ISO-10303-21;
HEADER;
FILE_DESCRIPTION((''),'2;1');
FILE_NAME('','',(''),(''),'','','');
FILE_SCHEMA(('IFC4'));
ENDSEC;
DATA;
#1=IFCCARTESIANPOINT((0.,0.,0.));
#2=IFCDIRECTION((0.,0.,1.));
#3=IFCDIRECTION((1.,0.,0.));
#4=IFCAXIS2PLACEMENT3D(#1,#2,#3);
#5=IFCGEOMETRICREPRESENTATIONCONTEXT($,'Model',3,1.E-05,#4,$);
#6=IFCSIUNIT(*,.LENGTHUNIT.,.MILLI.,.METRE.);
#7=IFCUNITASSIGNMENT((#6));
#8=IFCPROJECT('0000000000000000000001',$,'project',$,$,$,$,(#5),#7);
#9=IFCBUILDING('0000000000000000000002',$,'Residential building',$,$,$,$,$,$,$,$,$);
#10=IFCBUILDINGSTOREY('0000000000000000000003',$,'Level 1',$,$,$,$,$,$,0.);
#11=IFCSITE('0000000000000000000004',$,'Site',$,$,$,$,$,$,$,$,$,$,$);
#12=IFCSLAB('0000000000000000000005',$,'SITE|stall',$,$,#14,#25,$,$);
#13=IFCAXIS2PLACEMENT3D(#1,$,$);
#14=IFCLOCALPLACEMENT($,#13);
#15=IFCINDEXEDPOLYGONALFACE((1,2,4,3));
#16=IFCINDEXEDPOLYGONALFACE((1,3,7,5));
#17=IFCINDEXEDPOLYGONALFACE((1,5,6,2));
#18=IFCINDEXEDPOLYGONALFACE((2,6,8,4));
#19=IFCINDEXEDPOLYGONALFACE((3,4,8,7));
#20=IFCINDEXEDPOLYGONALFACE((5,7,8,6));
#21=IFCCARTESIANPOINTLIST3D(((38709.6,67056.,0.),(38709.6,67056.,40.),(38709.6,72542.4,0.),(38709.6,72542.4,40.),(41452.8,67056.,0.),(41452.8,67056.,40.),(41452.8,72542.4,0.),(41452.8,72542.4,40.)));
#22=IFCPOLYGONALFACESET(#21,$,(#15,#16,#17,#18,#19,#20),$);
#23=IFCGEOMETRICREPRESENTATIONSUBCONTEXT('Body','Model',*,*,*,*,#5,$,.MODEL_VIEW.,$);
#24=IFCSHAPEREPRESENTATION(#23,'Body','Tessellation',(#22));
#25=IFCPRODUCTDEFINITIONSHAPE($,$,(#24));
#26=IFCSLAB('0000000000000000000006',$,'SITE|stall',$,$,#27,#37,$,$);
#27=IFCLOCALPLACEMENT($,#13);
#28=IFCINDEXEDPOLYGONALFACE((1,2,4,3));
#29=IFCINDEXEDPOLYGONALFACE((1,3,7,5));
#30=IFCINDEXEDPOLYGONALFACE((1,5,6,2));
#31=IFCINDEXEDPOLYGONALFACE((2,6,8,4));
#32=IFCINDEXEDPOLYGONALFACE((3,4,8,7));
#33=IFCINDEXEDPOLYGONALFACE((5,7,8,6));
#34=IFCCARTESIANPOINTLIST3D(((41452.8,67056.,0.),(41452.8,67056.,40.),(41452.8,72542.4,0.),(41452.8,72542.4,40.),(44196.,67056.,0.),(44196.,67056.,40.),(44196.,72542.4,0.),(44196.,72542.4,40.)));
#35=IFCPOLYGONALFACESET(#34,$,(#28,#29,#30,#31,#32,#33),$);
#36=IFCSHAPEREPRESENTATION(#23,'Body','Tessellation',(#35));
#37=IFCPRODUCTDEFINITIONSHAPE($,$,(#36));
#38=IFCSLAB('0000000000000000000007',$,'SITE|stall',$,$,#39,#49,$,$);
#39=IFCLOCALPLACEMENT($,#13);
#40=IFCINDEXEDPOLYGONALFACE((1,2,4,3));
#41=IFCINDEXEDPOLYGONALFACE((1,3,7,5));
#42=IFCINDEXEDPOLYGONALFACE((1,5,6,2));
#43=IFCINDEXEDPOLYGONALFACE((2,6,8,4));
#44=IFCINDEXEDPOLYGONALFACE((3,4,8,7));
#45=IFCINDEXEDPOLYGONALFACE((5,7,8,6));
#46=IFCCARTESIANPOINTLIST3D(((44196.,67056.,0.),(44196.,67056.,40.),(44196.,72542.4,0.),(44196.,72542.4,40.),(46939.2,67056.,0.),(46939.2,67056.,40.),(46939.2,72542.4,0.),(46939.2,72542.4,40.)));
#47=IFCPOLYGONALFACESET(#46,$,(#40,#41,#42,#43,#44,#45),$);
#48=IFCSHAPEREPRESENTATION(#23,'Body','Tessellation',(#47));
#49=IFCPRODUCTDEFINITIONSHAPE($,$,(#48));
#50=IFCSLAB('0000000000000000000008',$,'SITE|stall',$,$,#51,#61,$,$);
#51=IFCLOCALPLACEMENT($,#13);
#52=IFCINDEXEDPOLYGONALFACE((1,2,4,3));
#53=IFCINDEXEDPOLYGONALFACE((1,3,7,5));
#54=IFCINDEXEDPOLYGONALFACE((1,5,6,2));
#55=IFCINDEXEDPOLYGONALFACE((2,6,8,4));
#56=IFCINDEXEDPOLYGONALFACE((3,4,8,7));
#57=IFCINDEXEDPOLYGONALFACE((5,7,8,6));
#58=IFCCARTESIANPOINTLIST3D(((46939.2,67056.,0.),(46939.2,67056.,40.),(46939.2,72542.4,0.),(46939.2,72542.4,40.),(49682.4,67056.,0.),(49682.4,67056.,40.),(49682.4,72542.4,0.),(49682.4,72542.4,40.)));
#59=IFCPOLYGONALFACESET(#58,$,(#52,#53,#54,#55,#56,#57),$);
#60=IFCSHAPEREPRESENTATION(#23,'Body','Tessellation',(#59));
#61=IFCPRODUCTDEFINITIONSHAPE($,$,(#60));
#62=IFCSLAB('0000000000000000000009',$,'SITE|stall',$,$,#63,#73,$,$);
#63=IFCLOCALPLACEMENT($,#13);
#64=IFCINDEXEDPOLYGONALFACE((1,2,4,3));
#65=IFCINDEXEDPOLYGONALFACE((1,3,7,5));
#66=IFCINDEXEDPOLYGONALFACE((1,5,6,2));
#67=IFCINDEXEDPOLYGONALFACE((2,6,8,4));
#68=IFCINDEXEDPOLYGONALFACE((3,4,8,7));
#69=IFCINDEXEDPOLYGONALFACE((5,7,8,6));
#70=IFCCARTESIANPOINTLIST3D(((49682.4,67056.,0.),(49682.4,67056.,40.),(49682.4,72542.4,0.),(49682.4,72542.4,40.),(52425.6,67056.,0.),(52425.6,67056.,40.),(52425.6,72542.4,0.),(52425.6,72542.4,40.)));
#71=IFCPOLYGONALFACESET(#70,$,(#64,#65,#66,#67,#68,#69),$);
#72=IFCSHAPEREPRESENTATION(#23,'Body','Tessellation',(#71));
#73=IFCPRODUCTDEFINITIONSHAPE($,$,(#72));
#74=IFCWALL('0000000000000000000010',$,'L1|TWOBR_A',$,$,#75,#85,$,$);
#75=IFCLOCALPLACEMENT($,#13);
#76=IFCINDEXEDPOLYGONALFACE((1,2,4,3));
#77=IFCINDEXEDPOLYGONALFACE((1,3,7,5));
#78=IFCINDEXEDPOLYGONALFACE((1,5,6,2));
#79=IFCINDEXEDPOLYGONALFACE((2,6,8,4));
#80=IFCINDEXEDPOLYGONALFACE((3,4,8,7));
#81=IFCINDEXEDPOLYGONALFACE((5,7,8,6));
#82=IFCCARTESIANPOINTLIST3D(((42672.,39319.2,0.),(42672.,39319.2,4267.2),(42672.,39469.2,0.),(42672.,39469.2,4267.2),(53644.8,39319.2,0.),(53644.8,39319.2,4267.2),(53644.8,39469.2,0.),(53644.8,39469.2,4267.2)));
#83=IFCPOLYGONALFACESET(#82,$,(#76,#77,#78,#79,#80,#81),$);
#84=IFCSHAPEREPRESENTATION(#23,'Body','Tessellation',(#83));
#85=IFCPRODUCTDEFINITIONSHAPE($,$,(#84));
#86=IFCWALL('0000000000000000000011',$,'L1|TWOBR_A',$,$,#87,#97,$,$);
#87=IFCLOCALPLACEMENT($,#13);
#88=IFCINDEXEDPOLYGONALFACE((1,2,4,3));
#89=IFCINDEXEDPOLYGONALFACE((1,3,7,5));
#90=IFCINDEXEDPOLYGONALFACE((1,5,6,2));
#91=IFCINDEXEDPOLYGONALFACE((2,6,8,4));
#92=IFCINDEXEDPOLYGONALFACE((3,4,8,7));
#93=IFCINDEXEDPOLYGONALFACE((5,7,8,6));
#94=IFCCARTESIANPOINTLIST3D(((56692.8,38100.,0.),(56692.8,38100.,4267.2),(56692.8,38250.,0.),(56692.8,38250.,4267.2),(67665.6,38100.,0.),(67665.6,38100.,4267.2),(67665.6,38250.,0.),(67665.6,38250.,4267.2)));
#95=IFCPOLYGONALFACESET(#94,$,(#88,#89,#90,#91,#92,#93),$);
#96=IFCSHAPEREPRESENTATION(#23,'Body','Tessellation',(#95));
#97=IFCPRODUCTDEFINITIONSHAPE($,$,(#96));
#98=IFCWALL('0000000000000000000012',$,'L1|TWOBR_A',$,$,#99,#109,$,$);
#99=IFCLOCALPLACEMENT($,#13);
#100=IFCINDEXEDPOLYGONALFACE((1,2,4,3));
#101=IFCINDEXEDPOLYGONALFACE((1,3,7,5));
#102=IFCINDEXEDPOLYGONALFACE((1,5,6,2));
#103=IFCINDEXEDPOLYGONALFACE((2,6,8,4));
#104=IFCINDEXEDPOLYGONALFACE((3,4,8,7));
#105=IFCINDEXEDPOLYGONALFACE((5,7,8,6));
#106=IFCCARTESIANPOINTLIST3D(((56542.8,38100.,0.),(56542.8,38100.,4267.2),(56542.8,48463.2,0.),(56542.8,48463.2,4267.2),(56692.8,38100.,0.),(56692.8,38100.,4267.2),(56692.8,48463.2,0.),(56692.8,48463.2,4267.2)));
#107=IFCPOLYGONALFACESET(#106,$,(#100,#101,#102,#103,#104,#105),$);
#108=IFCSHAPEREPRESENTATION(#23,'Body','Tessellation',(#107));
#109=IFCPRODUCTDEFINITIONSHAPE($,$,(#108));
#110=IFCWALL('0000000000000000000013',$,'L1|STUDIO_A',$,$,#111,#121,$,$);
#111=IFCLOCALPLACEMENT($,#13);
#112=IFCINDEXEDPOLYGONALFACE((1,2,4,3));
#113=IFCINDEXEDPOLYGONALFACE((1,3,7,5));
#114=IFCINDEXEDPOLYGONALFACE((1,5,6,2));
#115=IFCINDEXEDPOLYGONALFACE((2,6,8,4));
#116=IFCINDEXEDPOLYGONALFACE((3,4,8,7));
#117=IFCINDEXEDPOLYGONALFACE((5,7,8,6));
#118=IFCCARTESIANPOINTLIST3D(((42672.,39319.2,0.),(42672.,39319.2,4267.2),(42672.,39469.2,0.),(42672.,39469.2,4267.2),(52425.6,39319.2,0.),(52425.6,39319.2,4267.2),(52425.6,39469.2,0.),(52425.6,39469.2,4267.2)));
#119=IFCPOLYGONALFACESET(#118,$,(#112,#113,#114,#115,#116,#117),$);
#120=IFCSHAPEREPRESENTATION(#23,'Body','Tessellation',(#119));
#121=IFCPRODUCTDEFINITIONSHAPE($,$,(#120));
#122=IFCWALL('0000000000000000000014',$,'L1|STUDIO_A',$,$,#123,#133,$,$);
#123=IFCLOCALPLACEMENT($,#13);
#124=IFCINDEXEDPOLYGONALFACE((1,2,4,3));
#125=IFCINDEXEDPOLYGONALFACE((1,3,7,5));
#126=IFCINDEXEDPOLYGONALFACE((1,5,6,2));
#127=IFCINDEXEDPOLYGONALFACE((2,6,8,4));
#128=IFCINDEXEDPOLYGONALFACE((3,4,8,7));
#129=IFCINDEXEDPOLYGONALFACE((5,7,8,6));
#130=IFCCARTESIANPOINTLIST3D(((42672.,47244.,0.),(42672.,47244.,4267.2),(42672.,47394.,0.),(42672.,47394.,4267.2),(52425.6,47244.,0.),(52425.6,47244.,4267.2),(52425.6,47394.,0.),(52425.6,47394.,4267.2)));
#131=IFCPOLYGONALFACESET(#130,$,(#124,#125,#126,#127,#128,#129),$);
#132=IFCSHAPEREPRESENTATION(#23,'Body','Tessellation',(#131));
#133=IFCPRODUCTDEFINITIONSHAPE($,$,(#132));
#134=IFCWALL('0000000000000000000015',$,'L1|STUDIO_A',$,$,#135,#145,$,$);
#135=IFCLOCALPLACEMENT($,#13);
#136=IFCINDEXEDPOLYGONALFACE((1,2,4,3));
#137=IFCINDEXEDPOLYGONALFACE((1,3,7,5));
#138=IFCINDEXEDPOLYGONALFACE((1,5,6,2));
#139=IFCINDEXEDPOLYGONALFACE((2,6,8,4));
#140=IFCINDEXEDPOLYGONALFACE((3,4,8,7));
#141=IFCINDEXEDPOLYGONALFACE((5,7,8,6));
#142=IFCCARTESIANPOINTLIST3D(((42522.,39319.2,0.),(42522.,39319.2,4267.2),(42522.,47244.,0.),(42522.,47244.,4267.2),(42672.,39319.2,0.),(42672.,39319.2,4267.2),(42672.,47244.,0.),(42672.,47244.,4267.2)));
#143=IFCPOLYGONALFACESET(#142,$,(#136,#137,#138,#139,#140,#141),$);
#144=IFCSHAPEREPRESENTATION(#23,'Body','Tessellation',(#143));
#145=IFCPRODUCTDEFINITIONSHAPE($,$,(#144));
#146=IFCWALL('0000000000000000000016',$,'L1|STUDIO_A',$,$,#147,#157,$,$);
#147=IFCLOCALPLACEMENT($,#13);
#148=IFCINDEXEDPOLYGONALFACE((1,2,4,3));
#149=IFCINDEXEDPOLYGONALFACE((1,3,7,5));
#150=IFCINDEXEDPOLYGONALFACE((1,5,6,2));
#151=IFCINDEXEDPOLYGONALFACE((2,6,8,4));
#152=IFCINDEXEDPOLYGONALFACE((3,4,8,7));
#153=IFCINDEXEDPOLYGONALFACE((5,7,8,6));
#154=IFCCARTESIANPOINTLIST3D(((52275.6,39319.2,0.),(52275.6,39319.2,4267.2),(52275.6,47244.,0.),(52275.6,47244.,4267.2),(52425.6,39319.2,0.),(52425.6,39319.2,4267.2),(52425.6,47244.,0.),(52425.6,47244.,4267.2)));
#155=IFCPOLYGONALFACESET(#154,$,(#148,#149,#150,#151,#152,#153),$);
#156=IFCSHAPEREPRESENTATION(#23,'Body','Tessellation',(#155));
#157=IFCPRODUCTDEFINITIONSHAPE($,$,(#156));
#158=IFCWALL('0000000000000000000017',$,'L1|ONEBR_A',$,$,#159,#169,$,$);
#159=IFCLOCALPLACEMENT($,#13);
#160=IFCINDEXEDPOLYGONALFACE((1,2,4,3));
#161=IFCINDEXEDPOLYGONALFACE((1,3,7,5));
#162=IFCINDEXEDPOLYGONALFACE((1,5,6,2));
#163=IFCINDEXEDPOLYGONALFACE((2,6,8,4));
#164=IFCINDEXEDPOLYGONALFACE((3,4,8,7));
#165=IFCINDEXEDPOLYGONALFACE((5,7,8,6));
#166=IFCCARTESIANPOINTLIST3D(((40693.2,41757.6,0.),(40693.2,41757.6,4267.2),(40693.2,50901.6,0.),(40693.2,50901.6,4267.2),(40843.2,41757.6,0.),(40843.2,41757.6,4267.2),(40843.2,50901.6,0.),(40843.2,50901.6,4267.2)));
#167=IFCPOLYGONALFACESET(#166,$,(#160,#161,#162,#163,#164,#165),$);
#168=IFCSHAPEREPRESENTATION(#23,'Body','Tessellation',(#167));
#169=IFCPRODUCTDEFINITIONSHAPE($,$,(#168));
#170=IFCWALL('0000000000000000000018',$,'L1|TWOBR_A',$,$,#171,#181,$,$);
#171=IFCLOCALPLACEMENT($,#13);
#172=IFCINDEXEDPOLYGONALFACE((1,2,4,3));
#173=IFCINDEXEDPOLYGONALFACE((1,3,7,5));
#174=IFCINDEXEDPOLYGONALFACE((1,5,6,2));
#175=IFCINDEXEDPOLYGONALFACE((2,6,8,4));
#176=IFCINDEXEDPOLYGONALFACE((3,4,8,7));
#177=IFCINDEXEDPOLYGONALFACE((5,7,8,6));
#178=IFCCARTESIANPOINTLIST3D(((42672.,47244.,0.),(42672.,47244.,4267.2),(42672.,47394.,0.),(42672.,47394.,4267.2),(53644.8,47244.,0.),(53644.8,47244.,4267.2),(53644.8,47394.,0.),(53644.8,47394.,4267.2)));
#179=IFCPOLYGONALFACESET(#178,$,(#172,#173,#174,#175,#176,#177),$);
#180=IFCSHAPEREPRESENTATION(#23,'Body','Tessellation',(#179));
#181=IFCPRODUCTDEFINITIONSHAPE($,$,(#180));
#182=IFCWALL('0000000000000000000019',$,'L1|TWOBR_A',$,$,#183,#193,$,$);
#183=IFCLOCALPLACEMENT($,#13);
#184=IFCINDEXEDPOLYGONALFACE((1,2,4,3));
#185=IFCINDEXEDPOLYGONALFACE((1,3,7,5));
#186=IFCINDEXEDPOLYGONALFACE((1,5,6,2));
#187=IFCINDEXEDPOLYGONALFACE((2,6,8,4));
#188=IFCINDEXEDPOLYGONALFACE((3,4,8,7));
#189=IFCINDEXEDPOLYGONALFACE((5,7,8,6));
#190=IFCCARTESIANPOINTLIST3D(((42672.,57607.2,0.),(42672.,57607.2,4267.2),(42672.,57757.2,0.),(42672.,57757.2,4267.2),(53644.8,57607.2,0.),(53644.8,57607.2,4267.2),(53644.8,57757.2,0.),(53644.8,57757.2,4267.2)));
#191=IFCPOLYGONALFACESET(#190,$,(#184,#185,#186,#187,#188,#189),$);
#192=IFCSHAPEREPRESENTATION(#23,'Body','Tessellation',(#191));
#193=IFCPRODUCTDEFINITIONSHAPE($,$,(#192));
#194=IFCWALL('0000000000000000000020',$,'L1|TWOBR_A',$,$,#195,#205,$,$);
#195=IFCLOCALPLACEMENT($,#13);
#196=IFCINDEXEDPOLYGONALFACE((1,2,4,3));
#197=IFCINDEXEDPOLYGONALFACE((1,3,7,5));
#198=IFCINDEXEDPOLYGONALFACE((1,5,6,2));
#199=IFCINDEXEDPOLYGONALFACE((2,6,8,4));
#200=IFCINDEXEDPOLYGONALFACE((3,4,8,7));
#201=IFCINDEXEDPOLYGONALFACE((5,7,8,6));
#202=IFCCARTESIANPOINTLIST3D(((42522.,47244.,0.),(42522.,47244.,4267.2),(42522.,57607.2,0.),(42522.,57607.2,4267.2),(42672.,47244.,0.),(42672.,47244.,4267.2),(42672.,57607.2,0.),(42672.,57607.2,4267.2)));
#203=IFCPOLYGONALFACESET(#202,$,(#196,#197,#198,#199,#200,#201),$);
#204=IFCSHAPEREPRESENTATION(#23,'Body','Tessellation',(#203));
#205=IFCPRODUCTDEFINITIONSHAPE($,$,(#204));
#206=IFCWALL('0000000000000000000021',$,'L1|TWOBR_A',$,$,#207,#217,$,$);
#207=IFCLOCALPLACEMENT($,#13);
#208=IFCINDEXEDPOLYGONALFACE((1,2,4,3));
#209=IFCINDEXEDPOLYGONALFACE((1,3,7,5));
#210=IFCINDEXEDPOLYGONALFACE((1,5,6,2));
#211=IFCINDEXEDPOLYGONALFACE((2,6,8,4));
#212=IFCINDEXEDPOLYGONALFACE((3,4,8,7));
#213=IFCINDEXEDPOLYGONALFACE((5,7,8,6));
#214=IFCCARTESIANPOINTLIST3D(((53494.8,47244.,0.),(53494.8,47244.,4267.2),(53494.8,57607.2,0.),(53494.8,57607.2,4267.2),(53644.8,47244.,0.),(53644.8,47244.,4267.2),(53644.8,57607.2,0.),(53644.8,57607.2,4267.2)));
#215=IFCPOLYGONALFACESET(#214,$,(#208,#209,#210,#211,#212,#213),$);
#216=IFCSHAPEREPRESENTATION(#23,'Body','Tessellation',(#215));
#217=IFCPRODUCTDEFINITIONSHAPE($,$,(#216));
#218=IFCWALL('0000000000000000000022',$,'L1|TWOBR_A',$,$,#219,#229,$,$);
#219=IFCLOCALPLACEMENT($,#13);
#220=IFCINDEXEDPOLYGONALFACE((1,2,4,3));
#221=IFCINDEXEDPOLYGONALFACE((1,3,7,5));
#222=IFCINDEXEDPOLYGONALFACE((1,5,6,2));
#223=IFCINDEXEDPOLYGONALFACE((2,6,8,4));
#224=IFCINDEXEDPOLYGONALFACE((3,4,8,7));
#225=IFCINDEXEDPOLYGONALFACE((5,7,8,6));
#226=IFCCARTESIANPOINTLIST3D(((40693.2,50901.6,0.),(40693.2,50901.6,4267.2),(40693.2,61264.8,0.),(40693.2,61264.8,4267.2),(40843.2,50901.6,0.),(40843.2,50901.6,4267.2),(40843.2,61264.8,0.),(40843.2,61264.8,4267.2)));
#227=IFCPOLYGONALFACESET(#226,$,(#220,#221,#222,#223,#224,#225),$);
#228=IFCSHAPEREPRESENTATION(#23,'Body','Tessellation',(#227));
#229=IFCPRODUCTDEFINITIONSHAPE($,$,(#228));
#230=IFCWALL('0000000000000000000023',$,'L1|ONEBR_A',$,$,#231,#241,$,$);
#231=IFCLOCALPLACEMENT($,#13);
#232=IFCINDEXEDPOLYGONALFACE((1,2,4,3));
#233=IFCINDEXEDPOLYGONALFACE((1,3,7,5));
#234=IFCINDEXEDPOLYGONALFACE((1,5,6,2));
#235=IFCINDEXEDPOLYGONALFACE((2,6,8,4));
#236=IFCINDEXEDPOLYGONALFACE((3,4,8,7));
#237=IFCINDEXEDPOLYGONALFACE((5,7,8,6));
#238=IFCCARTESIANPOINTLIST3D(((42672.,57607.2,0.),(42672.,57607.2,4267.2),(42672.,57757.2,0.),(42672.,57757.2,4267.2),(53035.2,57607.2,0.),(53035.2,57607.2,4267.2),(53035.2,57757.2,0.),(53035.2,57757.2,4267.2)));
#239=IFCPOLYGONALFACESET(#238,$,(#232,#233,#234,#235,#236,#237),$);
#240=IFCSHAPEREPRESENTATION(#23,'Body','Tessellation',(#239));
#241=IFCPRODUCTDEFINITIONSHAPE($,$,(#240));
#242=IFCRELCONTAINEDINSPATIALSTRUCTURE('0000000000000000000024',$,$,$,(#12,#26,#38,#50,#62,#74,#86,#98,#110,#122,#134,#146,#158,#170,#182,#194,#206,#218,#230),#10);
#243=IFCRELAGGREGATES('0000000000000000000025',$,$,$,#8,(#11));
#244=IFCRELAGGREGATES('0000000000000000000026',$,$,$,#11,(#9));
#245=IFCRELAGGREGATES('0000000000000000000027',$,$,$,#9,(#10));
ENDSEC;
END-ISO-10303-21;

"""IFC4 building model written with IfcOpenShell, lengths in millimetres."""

from ifc_helpers import new_model, si_unit, frame, origin_with_axes, place, context, subcontext, project, spatial, indexed_curve, outline, extrude, element, save


model = new_model("IFC4")

# Units and contexts
model_context = context("Model", 3, precision=1e-05, world=origin_with_axes())
body_context = subcontext(model_context, "Body", "Model", "MODEL_VIEW")
ifc_project = project(units=[si_unit("LENGTHUNIT", "METRE", prefix="MILLI")], contexts=[model_context])

# Site, building, storey
site = spatial("IfcSite", under=ifc_project, Name="Site")
building = spatial("IfcBuilding", under=site, Name="Residential building")
storey = spatial("IfcBuildingStorey", under=building, Name="Level 1", Elevation=0.0)

# Slabs
for number, where, z_axis, x_axis, name in (
    (1, (38709.6, 67056.0, 0.0), (0.0, 0.0, 1.0), (1.0, 0.0, 0.0), "SITE|stall"),
    (2, (41452.8, 67056.0, 0.0), (0.0, 0.0, 1.0), (1.0, 0.0, 0.0), "SITE|stall"),
    (3, (44196.0, 67056.0, 0.0), (0.0, 0.0, 1.0), (1.0, 0.0, 0.0), "SITE|stall"),
    (4, (46939.2, 67056.0, 0.0), (0.0, 0.0, 1.0), (1.0, 0.0, 0.0), "SITE|stall"),
    (5, (49682.4, 67056.0, 0.0), (0.0, 0.0, 1.0), (1.0, 0.0, 0.0), "SITE|stall"),
):
    element("IfcSlab", number, at=place(None, frame(where, z_axis=z_axis, x_axis=x_axis)), inside=storey, Name=name, context=body_context, shape_type="SweptSolid", body=[
        extrude(outline(indexed_curve([(0.0, 0.0), (2743.2, 0.0), (2743.2, 5486.4), (0.0, 5486.4), (0.0, 0.0)])), None, (0.0, 0.0, 1.0), 40.0),
    ])

# Walls
for number, where, z_axis, x_axis, name in (
    (6, (42672.0, 39319.2, 0.0), (0.0, 0.0, 1.0), (1.0, 0.0, 0.0), "L1|TWOBR_A"),
    (7, (56692.8, 38100.0, 0.0), (0.0, 0.0, 1.0), (1.0, 0.0, 0.0), "L1|TWOBR_A"),
):
    element("IfcWall", number, at=place(None, frame(where, z_axis=z_axis, x_axis=x_axis)), inside=storey, Name=name, context=body_context, shape_type="SweptSolid", body=[
        extrude(outline(indexed_curve([(0.0, 0.0), (0.0, 150.0), (10972.8, 150.0), (10972.8, 0.0), (0.0, 0.0)], self_intersect=False)), origin_with_axes(), (0.0, 0.0, 1.0), 4267.2),
    ])
wall_1_placement = place(None, frame((56692.8, 38100.0, 0.0), z_axis=(0.0, 0.0, 1.0), x_axis=(0.0, 1.0, 0.0)))
element("IfcWall", 8, at=wall_1_placement, inside=storey, Name="L1|TWOBR_A", context=body_context, shape_type="SweptSolid", body=[
    extrude(outline(indexed_curve([(0.0, 0.0), (0.0, 150.0), (10363.2, 150.0), (10363.2, 0.0), (0.0, 0.0)], self_intersect=False)), origin_with_axes(), (0.0, 0.0, 1.0), 4267.2),
])
for number, where, z_axis, x_axis, name in (
    (9, (42672.0, 39319.2, 0.0), (0.0, 0.0, 1.0), (1.0, 0.0, 0.0), "L1|STUDIO_A"),
    (10, (42672.0, 47244.0, 0.0), (0.0, 0.0, 1.0), (1.0, 0.0, 0.0), "L1|STUDIO_A"),
):
    element("IfcWall", number, at=place(None, frame(where, z_axis=z_axis, x_axis=x_axis)), inside=storey, Name=name, context=body_context, shape_type="SweptSolid", body=[
        extrude(outline(indexed_curve([(0.0, 0.0), (0.0, 150.0), (9753.6, 150.0), (9753.6, 0.0), (0.0, 0.0)], self_intersect=False)), origin_with_axes(), (0.0, 0.0, 1.0), 4267.2),
    ])
for number, where, z_axis, x_axis, name in (
    (11, (42672.0, 39319.2, 0.0), (0.0, 0.0, 1.0), (0.0, 1.0, 0.0), "L1|STUDIO_A"),
    (12, (52425.6, 39319.2, 0.0), (0.0, 0.0, 1.0), (0.0, 1.0, 0.0), "L1|STUDIO_A"),
):
    element("IfcWall", number, at=place(None, frame(where, z_axis=z_axis, x_axis=x_axis)), inside=storey, Name=name, context=body_context, shape_type="SweptSolid", body=[
        extrude(outline(indexed_curve([(0.0, 0.0), (0.0, 150.0), (7924.8, 150.0), (7924.8, 0.0), (0.0, 0.0)], self_intersect=False)), origin_with_axes(), (0.0, 0.0, 1.0), 4267.2),
    ])
wall_2_placement = place(None, frame((40843.2, 41757.6, 0.0), z_axis=(0.0, 0.0, 1.0), x_axis=(0.0, 1.0, 0.0)))
element("IfcWall", 13, at=wall_2_placement, inside=storey, Name="L1|ONEBR_A", context=body_context, shape_type="SweptSolid", body=[
    extrude(outline(indexed_curve([(0.0, 0.0), (0.0, 150.0), (9144.0, 150.0), (9144.0, 0.0), (0.0, 0.0)], self_intersect=False)), origin_with_axes(), (0.0, 0.0, 1.0), 4267.2),
])
for number, where, z_axis, x_axis, name in (
    (14, (42672.0, 47244.0, 0.0), (0.0, 0.0, 1.0), (1.0, 0.0, 0.0), "L1|TWOBR_A"),
    (15, (42672.0, 57607.2, 0.0), (0.0, 0.0, 1.0), (1.0, 0.0, 0.0), "L1|TWOBR_A"),
):
    element("IfcWall", number, at=place(None, frame(where, z_axis=z_axis, x_axis=x_axis)), inside=storey, Name=name, context=body_context, shape_type="SweptSolid", body=[
        extrude(outline(indexed_curve([(0.0, 0.0), (0.0, 150.0), (10972.8, 150.0), (10972.8, 0.0), (0.0, 0.0)], self_intersect=False)), origin_with_axes(), (0.0, 0.0, 1.0), 4267.2),
    ])
for number, where, z_axis, x_axis, name in (
    (16, (42672.0, 47244.0, 0.0), (0.0, 0.0, 1.0), (0.0, 1.0, 0.0), "L1|TWOBR_A"),
    (17, (53644.8, 47244.0, 0.0), (0.0, 0.0, 1.0), (0.0, 1.0, 0.0), "L1|TWOBR_A"),
    (18, (40843.2, 50901.6, 0.0), (0.0, 0.0, 1.0), (0.0, 1.0, 0.0), "L1|TWOBR_A"),
    (19, (42672.0, 57607.2, 0.0), (0.0, 0.0, 1.0), (1.0, 0.0, 0.0), "L1|ONEBR_A"),
):
    element("IfcWall", number, at=place(None, frame(where, z_axis=z_axis, x_axis=x_axis)), inside=storey, Name=name, context=body_context, shape_type="SweptSolid", body=[
        extrude(outline(indexed_curve([(0.0, 0.0), (0.0, 150.0), (10363.2, 150.0), (10363.2, 0.0), (0.0, 0.0)], self_intersect=False)), origin_with_axes(), (0.0, 0.0, 1.0), 4267.2),
    ])

save(model, "model.ifc")
